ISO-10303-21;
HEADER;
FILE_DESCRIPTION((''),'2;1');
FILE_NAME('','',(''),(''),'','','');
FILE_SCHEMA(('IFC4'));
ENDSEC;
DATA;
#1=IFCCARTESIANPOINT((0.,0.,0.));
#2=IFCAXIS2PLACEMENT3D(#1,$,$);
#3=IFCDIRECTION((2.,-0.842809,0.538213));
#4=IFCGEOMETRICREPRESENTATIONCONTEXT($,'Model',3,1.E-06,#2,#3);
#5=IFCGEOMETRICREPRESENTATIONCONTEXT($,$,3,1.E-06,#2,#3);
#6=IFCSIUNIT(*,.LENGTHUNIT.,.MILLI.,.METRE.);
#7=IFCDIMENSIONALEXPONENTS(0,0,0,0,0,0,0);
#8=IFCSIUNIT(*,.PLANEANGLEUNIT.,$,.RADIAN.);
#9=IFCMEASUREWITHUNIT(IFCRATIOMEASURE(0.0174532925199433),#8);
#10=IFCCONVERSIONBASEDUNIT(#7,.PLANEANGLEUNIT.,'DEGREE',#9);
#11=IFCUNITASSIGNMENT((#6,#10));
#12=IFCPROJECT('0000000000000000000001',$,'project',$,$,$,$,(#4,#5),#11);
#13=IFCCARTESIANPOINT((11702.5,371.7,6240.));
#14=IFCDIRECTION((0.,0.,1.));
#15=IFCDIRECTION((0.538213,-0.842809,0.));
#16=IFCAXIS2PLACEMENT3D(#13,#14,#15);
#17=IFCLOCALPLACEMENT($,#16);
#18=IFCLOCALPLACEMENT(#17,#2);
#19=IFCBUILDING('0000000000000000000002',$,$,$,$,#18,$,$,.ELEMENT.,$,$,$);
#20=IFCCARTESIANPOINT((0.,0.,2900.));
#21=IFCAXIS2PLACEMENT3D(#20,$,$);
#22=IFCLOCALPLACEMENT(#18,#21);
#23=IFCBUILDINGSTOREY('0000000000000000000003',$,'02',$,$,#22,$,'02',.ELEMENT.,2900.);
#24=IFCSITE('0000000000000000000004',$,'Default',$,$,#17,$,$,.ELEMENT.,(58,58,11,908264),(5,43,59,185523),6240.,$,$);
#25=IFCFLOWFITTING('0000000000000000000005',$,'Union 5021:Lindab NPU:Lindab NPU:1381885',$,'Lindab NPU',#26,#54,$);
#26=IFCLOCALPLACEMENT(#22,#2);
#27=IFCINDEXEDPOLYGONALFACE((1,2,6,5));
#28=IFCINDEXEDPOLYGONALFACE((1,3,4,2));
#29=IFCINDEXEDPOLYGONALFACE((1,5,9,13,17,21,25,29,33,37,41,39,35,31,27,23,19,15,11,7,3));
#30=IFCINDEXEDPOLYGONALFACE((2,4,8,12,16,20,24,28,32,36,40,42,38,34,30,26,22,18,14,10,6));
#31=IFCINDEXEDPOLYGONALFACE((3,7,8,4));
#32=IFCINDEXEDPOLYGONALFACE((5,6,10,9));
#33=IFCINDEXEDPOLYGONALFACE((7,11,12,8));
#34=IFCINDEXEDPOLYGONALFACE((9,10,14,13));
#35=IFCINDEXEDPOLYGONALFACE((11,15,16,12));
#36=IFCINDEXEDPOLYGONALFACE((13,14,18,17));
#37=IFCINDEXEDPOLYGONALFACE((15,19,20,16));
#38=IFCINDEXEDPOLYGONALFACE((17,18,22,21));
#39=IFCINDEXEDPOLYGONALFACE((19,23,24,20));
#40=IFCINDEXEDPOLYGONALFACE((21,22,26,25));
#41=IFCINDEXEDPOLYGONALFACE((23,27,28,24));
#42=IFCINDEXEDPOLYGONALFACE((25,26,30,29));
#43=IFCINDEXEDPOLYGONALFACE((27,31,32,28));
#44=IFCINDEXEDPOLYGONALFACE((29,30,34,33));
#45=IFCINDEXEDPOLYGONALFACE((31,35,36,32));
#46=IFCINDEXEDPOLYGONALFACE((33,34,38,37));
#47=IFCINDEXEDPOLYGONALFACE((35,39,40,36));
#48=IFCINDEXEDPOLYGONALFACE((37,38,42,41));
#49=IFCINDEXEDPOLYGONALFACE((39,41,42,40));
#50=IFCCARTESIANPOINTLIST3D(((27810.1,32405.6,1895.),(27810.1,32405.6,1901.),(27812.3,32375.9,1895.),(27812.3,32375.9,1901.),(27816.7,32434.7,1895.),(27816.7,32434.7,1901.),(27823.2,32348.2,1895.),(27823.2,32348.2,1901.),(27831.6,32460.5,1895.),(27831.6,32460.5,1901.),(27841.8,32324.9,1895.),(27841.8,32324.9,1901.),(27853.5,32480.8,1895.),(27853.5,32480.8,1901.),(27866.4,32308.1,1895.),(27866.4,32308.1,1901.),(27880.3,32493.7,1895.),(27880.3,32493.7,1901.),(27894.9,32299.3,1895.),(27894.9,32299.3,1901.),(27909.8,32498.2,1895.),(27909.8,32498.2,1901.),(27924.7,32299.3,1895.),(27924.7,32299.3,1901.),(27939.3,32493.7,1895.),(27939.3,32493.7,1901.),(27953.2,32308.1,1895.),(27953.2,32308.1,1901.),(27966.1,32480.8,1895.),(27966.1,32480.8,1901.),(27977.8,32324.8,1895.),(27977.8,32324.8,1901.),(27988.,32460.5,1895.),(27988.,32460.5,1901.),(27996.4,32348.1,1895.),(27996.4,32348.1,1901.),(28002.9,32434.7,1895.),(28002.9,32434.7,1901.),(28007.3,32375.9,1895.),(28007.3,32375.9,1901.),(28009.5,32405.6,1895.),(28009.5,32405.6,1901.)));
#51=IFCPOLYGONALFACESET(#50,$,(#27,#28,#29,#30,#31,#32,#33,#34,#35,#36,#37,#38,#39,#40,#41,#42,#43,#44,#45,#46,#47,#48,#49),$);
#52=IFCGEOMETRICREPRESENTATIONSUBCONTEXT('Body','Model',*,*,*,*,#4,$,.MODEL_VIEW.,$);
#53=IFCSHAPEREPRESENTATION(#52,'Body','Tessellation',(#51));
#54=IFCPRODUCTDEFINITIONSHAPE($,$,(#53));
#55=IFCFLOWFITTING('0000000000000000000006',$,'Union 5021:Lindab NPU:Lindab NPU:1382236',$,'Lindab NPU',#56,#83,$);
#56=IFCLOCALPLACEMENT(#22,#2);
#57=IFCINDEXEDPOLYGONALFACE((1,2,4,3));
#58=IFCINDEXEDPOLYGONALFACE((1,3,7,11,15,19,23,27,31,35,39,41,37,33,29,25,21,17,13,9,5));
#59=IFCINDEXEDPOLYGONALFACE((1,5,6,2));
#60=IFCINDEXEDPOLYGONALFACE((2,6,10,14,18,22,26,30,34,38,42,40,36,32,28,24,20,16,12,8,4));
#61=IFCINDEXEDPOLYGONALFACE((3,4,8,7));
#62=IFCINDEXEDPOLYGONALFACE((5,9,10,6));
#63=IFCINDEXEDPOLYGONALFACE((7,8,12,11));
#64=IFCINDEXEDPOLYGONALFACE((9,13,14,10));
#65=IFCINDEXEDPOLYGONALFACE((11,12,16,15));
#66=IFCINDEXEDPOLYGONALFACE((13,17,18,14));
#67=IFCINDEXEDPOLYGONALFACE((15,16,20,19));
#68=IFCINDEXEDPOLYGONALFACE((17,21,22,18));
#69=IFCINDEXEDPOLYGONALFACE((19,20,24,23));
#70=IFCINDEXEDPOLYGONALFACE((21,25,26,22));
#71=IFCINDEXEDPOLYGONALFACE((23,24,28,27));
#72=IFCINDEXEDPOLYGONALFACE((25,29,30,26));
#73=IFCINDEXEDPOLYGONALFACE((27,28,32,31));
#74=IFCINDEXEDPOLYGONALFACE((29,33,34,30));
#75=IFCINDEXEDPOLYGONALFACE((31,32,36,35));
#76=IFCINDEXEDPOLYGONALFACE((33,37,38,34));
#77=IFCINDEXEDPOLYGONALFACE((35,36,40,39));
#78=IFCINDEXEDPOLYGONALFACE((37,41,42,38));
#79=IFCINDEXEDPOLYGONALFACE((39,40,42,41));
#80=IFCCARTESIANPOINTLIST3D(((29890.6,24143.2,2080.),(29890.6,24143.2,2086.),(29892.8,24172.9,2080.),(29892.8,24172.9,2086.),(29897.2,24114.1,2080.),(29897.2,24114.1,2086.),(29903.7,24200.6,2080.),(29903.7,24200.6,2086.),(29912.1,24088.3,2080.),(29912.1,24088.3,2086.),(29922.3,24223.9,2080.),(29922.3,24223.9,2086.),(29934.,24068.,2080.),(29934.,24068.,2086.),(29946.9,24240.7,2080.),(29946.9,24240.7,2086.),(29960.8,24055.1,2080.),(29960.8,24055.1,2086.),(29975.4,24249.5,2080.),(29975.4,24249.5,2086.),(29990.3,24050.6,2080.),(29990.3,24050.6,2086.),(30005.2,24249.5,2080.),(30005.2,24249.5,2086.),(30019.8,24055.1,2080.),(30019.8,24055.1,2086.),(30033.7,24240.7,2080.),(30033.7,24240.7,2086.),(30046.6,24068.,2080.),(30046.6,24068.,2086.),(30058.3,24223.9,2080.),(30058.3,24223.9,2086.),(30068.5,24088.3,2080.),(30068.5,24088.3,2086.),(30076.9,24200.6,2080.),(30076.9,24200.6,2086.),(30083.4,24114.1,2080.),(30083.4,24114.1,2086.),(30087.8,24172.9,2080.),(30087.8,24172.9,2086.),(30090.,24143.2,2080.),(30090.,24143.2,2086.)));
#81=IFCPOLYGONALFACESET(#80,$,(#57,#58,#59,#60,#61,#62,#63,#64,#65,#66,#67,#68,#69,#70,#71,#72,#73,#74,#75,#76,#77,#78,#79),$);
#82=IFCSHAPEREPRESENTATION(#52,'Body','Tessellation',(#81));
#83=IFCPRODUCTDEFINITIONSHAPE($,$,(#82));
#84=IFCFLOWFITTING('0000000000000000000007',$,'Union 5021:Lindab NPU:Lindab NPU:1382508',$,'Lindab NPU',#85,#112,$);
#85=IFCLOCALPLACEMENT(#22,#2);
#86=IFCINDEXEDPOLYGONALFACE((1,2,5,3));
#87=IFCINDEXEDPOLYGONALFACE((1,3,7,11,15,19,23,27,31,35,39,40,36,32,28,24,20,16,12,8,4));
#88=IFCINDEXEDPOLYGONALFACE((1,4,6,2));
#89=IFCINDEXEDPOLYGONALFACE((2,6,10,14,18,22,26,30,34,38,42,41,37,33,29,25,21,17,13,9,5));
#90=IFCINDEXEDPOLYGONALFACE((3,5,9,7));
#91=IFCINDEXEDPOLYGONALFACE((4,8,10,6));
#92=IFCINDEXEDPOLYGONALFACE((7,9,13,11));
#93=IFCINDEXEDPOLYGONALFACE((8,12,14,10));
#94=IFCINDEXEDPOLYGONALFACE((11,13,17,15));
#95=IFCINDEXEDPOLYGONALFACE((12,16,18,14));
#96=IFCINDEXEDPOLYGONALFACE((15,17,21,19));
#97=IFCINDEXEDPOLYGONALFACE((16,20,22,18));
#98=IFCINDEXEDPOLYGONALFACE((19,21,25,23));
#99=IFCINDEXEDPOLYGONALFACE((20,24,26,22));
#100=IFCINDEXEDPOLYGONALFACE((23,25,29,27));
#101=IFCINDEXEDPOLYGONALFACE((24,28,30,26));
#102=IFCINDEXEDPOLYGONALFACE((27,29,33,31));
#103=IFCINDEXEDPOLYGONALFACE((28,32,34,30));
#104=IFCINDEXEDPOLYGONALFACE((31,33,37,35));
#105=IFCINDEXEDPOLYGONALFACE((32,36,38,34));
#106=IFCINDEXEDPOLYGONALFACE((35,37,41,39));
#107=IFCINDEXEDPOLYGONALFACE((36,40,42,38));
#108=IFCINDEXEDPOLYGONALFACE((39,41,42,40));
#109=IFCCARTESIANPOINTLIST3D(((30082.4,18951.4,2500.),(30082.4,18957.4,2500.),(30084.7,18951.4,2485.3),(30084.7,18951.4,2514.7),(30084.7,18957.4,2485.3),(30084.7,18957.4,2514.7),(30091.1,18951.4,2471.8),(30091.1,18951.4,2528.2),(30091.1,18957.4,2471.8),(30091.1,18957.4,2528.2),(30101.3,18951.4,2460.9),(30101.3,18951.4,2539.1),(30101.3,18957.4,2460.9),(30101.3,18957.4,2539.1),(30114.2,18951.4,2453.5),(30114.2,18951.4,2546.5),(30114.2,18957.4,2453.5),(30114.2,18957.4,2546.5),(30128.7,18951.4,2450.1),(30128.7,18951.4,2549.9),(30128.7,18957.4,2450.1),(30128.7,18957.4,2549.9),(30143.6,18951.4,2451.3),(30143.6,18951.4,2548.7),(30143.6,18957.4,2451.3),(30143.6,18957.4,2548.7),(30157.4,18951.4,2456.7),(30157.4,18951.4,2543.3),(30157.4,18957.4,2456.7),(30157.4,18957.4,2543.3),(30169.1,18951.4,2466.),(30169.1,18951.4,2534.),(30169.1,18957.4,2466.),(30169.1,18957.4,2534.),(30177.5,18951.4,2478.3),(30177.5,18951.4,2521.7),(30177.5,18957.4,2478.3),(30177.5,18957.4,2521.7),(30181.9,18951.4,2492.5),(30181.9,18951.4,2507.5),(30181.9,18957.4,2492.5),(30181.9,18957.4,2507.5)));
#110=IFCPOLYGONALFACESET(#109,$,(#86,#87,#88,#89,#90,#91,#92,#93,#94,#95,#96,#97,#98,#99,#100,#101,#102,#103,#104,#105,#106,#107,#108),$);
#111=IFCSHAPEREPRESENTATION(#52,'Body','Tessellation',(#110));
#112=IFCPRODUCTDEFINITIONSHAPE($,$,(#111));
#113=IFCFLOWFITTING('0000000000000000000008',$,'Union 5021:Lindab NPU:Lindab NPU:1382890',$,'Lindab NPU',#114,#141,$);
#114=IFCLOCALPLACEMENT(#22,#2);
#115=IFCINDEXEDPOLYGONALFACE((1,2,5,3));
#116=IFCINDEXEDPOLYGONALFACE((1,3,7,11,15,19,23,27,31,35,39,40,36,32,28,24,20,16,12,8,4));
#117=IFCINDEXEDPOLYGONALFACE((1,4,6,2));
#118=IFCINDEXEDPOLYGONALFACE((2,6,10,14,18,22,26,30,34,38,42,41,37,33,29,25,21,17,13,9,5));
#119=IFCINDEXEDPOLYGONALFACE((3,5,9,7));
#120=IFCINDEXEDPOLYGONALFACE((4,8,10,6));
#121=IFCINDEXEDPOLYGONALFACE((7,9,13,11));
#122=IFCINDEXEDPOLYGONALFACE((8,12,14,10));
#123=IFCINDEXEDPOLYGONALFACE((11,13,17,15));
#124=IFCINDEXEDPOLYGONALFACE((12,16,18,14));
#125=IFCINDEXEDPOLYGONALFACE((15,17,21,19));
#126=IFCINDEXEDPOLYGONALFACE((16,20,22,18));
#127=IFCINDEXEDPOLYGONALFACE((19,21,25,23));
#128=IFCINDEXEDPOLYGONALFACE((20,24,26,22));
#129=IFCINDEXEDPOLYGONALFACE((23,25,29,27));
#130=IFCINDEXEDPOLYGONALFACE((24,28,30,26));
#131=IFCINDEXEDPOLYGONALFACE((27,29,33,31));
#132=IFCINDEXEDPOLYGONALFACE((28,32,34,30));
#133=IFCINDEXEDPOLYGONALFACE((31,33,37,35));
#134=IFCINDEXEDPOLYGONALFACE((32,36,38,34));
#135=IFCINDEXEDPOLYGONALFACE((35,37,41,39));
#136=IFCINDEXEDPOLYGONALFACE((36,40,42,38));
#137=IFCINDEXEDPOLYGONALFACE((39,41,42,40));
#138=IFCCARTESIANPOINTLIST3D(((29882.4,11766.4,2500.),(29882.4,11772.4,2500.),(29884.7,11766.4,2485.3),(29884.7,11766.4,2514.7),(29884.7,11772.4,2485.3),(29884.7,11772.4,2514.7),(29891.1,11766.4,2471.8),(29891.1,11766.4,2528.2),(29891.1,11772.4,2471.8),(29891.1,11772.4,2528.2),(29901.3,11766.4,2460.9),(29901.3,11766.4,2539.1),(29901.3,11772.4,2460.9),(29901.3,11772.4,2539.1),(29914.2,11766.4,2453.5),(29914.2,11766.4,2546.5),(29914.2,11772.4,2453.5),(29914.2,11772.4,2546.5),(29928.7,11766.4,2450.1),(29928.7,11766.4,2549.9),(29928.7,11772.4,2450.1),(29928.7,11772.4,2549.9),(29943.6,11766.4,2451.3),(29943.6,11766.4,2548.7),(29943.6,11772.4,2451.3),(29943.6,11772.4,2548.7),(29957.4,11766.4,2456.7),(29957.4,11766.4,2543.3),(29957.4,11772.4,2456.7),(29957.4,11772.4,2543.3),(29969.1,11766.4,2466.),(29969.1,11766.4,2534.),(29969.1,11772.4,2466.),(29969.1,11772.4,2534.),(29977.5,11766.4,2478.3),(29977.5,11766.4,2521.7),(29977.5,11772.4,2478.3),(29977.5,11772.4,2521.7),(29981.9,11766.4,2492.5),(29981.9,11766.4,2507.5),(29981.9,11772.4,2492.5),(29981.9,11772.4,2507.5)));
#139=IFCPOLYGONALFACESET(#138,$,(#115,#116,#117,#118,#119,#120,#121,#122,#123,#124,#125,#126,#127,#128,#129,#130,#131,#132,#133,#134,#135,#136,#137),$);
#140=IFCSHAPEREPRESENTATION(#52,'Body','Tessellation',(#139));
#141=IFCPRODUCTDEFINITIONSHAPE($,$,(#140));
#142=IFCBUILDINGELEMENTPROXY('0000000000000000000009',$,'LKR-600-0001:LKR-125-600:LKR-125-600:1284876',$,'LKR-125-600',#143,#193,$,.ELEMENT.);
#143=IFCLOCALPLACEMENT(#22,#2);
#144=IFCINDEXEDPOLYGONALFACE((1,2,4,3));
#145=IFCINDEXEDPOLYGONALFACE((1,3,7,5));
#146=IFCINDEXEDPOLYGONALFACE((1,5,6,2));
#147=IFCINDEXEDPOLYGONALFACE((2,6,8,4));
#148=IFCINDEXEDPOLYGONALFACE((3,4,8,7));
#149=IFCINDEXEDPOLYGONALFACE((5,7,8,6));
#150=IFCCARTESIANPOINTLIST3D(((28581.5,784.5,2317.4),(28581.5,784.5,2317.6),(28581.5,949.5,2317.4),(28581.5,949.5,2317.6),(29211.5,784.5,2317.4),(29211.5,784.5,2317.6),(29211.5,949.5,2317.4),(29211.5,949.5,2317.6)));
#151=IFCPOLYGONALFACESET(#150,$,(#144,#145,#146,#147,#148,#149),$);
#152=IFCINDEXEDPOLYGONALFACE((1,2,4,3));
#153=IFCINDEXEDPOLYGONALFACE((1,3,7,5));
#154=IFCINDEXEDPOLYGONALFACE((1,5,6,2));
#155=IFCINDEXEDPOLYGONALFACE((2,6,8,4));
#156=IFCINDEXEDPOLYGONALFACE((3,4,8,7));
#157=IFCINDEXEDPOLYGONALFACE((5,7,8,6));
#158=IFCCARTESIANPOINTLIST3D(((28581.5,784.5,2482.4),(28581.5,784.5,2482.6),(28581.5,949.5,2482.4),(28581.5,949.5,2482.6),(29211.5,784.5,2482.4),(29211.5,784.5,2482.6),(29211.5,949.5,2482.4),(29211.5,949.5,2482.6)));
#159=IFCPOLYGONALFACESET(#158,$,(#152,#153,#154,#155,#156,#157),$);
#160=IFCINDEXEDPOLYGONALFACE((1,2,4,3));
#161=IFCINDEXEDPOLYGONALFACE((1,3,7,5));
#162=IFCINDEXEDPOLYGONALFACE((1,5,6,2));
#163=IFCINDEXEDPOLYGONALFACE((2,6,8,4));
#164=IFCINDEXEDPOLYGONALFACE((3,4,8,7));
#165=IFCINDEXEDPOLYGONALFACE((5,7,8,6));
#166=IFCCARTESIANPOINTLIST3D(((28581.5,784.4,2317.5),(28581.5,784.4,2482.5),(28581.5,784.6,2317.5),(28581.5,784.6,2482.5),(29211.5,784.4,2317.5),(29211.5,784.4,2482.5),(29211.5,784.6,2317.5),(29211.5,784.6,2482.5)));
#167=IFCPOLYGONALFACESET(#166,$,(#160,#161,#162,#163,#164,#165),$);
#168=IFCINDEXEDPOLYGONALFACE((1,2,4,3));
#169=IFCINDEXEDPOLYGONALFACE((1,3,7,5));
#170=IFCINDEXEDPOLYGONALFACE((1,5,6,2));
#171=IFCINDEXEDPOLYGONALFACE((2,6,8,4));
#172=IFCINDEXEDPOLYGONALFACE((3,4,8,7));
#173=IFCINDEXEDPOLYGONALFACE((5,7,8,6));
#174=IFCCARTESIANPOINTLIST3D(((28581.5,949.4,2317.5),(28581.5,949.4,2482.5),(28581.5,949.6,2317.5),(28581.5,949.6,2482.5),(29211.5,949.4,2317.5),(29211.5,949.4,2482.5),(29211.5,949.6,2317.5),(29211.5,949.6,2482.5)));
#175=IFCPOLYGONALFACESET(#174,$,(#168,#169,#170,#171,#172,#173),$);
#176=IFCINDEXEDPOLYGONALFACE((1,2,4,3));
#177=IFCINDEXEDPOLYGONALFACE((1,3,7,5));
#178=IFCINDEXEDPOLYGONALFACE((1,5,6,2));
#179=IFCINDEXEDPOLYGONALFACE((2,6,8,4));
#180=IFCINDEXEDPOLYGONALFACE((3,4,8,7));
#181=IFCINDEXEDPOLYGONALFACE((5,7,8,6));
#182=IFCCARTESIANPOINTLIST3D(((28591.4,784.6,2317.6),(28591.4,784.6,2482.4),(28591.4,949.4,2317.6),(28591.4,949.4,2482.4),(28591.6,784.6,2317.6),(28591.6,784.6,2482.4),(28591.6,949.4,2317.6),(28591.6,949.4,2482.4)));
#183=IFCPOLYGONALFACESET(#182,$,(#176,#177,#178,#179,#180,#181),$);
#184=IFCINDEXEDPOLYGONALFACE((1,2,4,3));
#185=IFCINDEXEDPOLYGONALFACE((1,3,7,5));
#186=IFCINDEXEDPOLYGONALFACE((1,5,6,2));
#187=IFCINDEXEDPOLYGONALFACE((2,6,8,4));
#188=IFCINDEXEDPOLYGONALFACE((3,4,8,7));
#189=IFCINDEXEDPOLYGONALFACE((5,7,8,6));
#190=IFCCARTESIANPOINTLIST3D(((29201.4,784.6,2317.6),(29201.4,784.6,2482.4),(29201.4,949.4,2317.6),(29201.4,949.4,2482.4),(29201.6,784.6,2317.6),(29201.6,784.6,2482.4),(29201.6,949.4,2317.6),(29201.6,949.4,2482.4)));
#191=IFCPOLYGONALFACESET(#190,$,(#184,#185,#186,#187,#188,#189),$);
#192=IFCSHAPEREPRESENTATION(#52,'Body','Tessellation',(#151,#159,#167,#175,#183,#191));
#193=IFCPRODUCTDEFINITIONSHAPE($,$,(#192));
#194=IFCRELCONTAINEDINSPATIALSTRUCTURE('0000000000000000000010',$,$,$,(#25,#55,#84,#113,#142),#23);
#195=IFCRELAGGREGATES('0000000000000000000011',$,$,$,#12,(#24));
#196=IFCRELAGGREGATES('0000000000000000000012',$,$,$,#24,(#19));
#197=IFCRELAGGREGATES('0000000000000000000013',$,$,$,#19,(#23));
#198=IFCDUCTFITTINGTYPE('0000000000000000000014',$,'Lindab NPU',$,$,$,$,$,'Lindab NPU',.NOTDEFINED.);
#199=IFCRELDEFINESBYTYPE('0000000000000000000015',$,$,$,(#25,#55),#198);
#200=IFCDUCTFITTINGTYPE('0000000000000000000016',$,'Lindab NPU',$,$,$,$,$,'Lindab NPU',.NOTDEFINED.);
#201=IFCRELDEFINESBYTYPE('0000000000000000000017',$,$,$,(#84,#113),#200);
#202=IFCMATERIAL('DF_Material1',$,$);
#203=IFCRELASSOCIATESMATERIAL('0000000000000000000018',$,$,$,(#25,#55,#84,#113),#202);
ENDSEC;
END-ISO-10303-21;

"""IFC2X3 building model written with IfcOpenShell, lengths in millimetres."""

from ifc_helpers import new_model, entity, si_unit, converted_unit, direction, frame, frame_2d, origin, place, context, subcontext, project, spatial, rectangle, circle, extrude, source, transform, mapped, material, type_object, type_shapes, element, save


model = new_model("IFC2X3")

# Units and contexts
model_context = context("Model", 3, precision=1e-06, world=origin(), true_north=direction((2.0, -0.842809, 0.538213)))
context_of_model = context(None, 3, precision=1e-06, world=origin(), true_north=direction((2.0, -0.842809, 0.538213)))
body_context = subcontext(model_context, "Body", "Model", "MODEL_VIEW")
ifc_project = project(units=[si_unit("LENGTHUNIT", "METRE", prefix="MILLI"), converted_unit("PLANEANGLEUNIT", "DEGREE", entity("IfcRatioMeasure", 0.0174532925199433), si_unit("PLANEANGLEUNIT", "RADIAN"), dimensions=[0, 0, 0, 0, 0, 0, 0])], contexts=[model_context, context_of_model])

# Site, building, storey
site_placement = place(None, frame((11702.5, 371.7, 6240.0), z_axis=(0.0, 0.0, 1.0), x_axis=(0.538213, -0.842809, 0.0)))
site = spatial("IfcSite", under=ifc_project, at=site_placement, Name="Default", CompositionType="ELEMENT", RefLatitude=(58, 58, 11, 908264), RefLongitude=(5, 43, 59, 185523), RefElevation=6240.0)
building_placement = place(site_placement, origin())
building = spatial("IfcBuilding", under=site, at=building_placement, CompositionType="ELEMENT")
storey_placement = place(building_placement, frame((0.0, 0.0, 2900.0)))
storey = spatial("IfcBuildingStorey", under=building, at=storey_placement, Name="02", LongName="02", CompositionType="ELEMENT", Elevation=2900.0)

# Flow fittings
ifc_material = material(Name="DF_Material1")
duct_fitting_type_1 = type_object("IfcDuctFittingType", Name="Lindab NPU", ElementType="Lindab NPU", PredefinedType="NOTDEFINED")
shared_shape_1 = source(origin(), body_context, "Body", "SweptSolid", [
    extrude(circle(Radius=100.0, at=frame_2d((0.0, 0.0), x_axis=(1.0, 0.0))), frame((0.0, 0.0, 0.0), z_axis=(1.0, 0.0, 0.0), x_axis=(0.0, 1.0, 0.0)), (0.0, 0.0, 1.0), 6.0),
])
type_shapes(duct_fitting_type_1, [shared_shape_1])
for number, where, z_axis, x_axis, name in (
    (1, (27909.8, 32398.2, 1895.0), (-1.0, 0.000073, 0.0), (0.0, 0.0, 1.0), "Union 5021:Lindab NPU:Lindab NPU:1381885"),
    (2, (29990.3, 24150.6, 2080.0), (1.0, 0.0, 0.0), (0.0, 0.0, 1.0), "Union 5021:Lindab NPU:Lindab NPU:1382236"),
):
    element("IfcFlowFitting", number, at=place(storey_placement, frame(where, z_axis=z_axis, x_axis=x_axis)), inside=storey, type_object=duct_fitting_type_1, material=ifc_material, Name=name, ObjectType="Lindab NPU", context=body_context, shape_type="MappedRepresentation", body=[
        mapped(shared_shape_1, transform((0.0, 0.0, 0.0), scale=1.0)),
    ])
duct_fitting_type_2 = type_object("IfcDuctFittingType", Name="Lindab NPU", ElementType="Lindab NPU", PredefinedType="NOTDEFINED")
shared_shape_2 = source(origin(), body_context, "Body", "SweptSolid", [
    extrude(circle(Radius=50.0, at=frame_2d((0.0, 0.0), x_axis=(1.0, 0.0))), frame((0.0, 0.0, 0.0), z_axis=(1.0, 0.0, 0.0), x_axis=(0.0, 1.0, 0.0)), (0.0, 0.0, 1.0), 6.0),
])
type_shapes(duct_fitting_type_2, [shared_shape_2])
for number, where, z_axis, x_axis, name in (
    (3, (30132.4, 18951.4, 2500.0), (0.0, 0.0, 1.0), (0.0, 1.0, 0.0), "Union 5021:Lindab NPU:Lindab NPU:1382508"),
    (4, (29932.4, 11766.4, 2500.0), (0.0, 0.0, 1.0), (0.0, 1.0, 0.0), "Union 5021:Lindab NPU:Lindab NPU:1382890"),
):
    element("IfcFlowFitting", number, at=place(storey_placement, frame(where, z_axis=z_axis, x_axis=x_axis)), inside=storey, type_object=duct_fitting_type_2, material=ifc_material, Name=name, ObjectType="Lindab NPU", context=body_context, shape_type="MappedRepresentation", body=[
        mapped(shared_shape_2, transform((0.0, 0.0, 0.0), scale=1.0)),
    ])

# Building element proxy
shared_shape_3 = source(origin(), body_context, "Body", "SweptSolid", [
    extrude(rectangle(XDim=165.0, YDim=630.0, at=frame_2d((0.0, 0.0), x_axis=(1.0, 0.0))), frame((0.0, 0.0, -82.6), z_axis=(0.0, 0.0, 1.0), x_axis=(0.0, -1.0, 0.0)), (0.0, 0.0, 1.0), 0.2),
    extrude(rectangle(XDim=165.0, YDim=630.0, at=frame_2d((0.0, 0.0), x_axis=(1.0, 0.0))), frame((0.0, 0.0, 82.4), z_axis=(0.0, 0.0, 1.0), x_axis=(0.0, -1.0, 0.0)), (0.0, 0.0, 1.0), 0.2),
    extrude(rectangle(XDim=0.2, YDim=630.0, at=frame_2d((0.0, 0.0), x_axis=(1.0, 0.0))), frame((0.0, 82.5, -82.5), z_axis=(0.0, 0.0, 1.0), x_axis=(0.0, 1.0, 0.0)), (0.0, 0.0, 1.0), 165.0),
    extrude(rectangle(XDim=0.2, YDim=630.0, at=frame_2d((0.0, 0.0), x_axis=(1.0, 0.0))), frame((0.0, -82.5, -82.5), z_axis=(0.0, 0.0, 1.0), x_axis=(0.0, 1.0, 0.0)), (0.0, 0.0, 1.0), 165.0),
    extrude(rectangle(XDim=0.2, YDim=164.8, at=frame_2d((0.0, 0.0), x_axis=(1.0, 0.0))), frame((305.0, 0.0, -82.4)), (0.0, 0.0, 1.0), 164.8),
    extrude(rectangle(XDim=0.2, YDim=164.8, at=frame_2d((0.0, 0.0), x_axis=(1.0, 0.0))), frame((-305.0, 0.0, -82.4)), (0.0, 0.0, 1.0), 164.8),
])
for number, where, z_axis, x_axis, name in (
    (5, (28896.5, 867.0, 2400.0), (0.0, 0.0, 1.0), (-1.0, 0.0, 0.0), "LKR-600-0001:LKR-125-600:LKR-125-600:1284876"),
):
    element("IfcBuildingElementProxy", number, at=place(storey_placement, frame(where, z_axis=z_axis, x_axis=x_axis)), inside=storey, Name=name, ObjectType="LKR-125-600", CompositionType="ELEMENT", context=body_context, shape_type="MappedRepresentation", body=[
        mapped(shared_shape_3, transform((0.0, 0.0, 0.0), scale=1.0)),
    ])

save(model, "model.ifc")
